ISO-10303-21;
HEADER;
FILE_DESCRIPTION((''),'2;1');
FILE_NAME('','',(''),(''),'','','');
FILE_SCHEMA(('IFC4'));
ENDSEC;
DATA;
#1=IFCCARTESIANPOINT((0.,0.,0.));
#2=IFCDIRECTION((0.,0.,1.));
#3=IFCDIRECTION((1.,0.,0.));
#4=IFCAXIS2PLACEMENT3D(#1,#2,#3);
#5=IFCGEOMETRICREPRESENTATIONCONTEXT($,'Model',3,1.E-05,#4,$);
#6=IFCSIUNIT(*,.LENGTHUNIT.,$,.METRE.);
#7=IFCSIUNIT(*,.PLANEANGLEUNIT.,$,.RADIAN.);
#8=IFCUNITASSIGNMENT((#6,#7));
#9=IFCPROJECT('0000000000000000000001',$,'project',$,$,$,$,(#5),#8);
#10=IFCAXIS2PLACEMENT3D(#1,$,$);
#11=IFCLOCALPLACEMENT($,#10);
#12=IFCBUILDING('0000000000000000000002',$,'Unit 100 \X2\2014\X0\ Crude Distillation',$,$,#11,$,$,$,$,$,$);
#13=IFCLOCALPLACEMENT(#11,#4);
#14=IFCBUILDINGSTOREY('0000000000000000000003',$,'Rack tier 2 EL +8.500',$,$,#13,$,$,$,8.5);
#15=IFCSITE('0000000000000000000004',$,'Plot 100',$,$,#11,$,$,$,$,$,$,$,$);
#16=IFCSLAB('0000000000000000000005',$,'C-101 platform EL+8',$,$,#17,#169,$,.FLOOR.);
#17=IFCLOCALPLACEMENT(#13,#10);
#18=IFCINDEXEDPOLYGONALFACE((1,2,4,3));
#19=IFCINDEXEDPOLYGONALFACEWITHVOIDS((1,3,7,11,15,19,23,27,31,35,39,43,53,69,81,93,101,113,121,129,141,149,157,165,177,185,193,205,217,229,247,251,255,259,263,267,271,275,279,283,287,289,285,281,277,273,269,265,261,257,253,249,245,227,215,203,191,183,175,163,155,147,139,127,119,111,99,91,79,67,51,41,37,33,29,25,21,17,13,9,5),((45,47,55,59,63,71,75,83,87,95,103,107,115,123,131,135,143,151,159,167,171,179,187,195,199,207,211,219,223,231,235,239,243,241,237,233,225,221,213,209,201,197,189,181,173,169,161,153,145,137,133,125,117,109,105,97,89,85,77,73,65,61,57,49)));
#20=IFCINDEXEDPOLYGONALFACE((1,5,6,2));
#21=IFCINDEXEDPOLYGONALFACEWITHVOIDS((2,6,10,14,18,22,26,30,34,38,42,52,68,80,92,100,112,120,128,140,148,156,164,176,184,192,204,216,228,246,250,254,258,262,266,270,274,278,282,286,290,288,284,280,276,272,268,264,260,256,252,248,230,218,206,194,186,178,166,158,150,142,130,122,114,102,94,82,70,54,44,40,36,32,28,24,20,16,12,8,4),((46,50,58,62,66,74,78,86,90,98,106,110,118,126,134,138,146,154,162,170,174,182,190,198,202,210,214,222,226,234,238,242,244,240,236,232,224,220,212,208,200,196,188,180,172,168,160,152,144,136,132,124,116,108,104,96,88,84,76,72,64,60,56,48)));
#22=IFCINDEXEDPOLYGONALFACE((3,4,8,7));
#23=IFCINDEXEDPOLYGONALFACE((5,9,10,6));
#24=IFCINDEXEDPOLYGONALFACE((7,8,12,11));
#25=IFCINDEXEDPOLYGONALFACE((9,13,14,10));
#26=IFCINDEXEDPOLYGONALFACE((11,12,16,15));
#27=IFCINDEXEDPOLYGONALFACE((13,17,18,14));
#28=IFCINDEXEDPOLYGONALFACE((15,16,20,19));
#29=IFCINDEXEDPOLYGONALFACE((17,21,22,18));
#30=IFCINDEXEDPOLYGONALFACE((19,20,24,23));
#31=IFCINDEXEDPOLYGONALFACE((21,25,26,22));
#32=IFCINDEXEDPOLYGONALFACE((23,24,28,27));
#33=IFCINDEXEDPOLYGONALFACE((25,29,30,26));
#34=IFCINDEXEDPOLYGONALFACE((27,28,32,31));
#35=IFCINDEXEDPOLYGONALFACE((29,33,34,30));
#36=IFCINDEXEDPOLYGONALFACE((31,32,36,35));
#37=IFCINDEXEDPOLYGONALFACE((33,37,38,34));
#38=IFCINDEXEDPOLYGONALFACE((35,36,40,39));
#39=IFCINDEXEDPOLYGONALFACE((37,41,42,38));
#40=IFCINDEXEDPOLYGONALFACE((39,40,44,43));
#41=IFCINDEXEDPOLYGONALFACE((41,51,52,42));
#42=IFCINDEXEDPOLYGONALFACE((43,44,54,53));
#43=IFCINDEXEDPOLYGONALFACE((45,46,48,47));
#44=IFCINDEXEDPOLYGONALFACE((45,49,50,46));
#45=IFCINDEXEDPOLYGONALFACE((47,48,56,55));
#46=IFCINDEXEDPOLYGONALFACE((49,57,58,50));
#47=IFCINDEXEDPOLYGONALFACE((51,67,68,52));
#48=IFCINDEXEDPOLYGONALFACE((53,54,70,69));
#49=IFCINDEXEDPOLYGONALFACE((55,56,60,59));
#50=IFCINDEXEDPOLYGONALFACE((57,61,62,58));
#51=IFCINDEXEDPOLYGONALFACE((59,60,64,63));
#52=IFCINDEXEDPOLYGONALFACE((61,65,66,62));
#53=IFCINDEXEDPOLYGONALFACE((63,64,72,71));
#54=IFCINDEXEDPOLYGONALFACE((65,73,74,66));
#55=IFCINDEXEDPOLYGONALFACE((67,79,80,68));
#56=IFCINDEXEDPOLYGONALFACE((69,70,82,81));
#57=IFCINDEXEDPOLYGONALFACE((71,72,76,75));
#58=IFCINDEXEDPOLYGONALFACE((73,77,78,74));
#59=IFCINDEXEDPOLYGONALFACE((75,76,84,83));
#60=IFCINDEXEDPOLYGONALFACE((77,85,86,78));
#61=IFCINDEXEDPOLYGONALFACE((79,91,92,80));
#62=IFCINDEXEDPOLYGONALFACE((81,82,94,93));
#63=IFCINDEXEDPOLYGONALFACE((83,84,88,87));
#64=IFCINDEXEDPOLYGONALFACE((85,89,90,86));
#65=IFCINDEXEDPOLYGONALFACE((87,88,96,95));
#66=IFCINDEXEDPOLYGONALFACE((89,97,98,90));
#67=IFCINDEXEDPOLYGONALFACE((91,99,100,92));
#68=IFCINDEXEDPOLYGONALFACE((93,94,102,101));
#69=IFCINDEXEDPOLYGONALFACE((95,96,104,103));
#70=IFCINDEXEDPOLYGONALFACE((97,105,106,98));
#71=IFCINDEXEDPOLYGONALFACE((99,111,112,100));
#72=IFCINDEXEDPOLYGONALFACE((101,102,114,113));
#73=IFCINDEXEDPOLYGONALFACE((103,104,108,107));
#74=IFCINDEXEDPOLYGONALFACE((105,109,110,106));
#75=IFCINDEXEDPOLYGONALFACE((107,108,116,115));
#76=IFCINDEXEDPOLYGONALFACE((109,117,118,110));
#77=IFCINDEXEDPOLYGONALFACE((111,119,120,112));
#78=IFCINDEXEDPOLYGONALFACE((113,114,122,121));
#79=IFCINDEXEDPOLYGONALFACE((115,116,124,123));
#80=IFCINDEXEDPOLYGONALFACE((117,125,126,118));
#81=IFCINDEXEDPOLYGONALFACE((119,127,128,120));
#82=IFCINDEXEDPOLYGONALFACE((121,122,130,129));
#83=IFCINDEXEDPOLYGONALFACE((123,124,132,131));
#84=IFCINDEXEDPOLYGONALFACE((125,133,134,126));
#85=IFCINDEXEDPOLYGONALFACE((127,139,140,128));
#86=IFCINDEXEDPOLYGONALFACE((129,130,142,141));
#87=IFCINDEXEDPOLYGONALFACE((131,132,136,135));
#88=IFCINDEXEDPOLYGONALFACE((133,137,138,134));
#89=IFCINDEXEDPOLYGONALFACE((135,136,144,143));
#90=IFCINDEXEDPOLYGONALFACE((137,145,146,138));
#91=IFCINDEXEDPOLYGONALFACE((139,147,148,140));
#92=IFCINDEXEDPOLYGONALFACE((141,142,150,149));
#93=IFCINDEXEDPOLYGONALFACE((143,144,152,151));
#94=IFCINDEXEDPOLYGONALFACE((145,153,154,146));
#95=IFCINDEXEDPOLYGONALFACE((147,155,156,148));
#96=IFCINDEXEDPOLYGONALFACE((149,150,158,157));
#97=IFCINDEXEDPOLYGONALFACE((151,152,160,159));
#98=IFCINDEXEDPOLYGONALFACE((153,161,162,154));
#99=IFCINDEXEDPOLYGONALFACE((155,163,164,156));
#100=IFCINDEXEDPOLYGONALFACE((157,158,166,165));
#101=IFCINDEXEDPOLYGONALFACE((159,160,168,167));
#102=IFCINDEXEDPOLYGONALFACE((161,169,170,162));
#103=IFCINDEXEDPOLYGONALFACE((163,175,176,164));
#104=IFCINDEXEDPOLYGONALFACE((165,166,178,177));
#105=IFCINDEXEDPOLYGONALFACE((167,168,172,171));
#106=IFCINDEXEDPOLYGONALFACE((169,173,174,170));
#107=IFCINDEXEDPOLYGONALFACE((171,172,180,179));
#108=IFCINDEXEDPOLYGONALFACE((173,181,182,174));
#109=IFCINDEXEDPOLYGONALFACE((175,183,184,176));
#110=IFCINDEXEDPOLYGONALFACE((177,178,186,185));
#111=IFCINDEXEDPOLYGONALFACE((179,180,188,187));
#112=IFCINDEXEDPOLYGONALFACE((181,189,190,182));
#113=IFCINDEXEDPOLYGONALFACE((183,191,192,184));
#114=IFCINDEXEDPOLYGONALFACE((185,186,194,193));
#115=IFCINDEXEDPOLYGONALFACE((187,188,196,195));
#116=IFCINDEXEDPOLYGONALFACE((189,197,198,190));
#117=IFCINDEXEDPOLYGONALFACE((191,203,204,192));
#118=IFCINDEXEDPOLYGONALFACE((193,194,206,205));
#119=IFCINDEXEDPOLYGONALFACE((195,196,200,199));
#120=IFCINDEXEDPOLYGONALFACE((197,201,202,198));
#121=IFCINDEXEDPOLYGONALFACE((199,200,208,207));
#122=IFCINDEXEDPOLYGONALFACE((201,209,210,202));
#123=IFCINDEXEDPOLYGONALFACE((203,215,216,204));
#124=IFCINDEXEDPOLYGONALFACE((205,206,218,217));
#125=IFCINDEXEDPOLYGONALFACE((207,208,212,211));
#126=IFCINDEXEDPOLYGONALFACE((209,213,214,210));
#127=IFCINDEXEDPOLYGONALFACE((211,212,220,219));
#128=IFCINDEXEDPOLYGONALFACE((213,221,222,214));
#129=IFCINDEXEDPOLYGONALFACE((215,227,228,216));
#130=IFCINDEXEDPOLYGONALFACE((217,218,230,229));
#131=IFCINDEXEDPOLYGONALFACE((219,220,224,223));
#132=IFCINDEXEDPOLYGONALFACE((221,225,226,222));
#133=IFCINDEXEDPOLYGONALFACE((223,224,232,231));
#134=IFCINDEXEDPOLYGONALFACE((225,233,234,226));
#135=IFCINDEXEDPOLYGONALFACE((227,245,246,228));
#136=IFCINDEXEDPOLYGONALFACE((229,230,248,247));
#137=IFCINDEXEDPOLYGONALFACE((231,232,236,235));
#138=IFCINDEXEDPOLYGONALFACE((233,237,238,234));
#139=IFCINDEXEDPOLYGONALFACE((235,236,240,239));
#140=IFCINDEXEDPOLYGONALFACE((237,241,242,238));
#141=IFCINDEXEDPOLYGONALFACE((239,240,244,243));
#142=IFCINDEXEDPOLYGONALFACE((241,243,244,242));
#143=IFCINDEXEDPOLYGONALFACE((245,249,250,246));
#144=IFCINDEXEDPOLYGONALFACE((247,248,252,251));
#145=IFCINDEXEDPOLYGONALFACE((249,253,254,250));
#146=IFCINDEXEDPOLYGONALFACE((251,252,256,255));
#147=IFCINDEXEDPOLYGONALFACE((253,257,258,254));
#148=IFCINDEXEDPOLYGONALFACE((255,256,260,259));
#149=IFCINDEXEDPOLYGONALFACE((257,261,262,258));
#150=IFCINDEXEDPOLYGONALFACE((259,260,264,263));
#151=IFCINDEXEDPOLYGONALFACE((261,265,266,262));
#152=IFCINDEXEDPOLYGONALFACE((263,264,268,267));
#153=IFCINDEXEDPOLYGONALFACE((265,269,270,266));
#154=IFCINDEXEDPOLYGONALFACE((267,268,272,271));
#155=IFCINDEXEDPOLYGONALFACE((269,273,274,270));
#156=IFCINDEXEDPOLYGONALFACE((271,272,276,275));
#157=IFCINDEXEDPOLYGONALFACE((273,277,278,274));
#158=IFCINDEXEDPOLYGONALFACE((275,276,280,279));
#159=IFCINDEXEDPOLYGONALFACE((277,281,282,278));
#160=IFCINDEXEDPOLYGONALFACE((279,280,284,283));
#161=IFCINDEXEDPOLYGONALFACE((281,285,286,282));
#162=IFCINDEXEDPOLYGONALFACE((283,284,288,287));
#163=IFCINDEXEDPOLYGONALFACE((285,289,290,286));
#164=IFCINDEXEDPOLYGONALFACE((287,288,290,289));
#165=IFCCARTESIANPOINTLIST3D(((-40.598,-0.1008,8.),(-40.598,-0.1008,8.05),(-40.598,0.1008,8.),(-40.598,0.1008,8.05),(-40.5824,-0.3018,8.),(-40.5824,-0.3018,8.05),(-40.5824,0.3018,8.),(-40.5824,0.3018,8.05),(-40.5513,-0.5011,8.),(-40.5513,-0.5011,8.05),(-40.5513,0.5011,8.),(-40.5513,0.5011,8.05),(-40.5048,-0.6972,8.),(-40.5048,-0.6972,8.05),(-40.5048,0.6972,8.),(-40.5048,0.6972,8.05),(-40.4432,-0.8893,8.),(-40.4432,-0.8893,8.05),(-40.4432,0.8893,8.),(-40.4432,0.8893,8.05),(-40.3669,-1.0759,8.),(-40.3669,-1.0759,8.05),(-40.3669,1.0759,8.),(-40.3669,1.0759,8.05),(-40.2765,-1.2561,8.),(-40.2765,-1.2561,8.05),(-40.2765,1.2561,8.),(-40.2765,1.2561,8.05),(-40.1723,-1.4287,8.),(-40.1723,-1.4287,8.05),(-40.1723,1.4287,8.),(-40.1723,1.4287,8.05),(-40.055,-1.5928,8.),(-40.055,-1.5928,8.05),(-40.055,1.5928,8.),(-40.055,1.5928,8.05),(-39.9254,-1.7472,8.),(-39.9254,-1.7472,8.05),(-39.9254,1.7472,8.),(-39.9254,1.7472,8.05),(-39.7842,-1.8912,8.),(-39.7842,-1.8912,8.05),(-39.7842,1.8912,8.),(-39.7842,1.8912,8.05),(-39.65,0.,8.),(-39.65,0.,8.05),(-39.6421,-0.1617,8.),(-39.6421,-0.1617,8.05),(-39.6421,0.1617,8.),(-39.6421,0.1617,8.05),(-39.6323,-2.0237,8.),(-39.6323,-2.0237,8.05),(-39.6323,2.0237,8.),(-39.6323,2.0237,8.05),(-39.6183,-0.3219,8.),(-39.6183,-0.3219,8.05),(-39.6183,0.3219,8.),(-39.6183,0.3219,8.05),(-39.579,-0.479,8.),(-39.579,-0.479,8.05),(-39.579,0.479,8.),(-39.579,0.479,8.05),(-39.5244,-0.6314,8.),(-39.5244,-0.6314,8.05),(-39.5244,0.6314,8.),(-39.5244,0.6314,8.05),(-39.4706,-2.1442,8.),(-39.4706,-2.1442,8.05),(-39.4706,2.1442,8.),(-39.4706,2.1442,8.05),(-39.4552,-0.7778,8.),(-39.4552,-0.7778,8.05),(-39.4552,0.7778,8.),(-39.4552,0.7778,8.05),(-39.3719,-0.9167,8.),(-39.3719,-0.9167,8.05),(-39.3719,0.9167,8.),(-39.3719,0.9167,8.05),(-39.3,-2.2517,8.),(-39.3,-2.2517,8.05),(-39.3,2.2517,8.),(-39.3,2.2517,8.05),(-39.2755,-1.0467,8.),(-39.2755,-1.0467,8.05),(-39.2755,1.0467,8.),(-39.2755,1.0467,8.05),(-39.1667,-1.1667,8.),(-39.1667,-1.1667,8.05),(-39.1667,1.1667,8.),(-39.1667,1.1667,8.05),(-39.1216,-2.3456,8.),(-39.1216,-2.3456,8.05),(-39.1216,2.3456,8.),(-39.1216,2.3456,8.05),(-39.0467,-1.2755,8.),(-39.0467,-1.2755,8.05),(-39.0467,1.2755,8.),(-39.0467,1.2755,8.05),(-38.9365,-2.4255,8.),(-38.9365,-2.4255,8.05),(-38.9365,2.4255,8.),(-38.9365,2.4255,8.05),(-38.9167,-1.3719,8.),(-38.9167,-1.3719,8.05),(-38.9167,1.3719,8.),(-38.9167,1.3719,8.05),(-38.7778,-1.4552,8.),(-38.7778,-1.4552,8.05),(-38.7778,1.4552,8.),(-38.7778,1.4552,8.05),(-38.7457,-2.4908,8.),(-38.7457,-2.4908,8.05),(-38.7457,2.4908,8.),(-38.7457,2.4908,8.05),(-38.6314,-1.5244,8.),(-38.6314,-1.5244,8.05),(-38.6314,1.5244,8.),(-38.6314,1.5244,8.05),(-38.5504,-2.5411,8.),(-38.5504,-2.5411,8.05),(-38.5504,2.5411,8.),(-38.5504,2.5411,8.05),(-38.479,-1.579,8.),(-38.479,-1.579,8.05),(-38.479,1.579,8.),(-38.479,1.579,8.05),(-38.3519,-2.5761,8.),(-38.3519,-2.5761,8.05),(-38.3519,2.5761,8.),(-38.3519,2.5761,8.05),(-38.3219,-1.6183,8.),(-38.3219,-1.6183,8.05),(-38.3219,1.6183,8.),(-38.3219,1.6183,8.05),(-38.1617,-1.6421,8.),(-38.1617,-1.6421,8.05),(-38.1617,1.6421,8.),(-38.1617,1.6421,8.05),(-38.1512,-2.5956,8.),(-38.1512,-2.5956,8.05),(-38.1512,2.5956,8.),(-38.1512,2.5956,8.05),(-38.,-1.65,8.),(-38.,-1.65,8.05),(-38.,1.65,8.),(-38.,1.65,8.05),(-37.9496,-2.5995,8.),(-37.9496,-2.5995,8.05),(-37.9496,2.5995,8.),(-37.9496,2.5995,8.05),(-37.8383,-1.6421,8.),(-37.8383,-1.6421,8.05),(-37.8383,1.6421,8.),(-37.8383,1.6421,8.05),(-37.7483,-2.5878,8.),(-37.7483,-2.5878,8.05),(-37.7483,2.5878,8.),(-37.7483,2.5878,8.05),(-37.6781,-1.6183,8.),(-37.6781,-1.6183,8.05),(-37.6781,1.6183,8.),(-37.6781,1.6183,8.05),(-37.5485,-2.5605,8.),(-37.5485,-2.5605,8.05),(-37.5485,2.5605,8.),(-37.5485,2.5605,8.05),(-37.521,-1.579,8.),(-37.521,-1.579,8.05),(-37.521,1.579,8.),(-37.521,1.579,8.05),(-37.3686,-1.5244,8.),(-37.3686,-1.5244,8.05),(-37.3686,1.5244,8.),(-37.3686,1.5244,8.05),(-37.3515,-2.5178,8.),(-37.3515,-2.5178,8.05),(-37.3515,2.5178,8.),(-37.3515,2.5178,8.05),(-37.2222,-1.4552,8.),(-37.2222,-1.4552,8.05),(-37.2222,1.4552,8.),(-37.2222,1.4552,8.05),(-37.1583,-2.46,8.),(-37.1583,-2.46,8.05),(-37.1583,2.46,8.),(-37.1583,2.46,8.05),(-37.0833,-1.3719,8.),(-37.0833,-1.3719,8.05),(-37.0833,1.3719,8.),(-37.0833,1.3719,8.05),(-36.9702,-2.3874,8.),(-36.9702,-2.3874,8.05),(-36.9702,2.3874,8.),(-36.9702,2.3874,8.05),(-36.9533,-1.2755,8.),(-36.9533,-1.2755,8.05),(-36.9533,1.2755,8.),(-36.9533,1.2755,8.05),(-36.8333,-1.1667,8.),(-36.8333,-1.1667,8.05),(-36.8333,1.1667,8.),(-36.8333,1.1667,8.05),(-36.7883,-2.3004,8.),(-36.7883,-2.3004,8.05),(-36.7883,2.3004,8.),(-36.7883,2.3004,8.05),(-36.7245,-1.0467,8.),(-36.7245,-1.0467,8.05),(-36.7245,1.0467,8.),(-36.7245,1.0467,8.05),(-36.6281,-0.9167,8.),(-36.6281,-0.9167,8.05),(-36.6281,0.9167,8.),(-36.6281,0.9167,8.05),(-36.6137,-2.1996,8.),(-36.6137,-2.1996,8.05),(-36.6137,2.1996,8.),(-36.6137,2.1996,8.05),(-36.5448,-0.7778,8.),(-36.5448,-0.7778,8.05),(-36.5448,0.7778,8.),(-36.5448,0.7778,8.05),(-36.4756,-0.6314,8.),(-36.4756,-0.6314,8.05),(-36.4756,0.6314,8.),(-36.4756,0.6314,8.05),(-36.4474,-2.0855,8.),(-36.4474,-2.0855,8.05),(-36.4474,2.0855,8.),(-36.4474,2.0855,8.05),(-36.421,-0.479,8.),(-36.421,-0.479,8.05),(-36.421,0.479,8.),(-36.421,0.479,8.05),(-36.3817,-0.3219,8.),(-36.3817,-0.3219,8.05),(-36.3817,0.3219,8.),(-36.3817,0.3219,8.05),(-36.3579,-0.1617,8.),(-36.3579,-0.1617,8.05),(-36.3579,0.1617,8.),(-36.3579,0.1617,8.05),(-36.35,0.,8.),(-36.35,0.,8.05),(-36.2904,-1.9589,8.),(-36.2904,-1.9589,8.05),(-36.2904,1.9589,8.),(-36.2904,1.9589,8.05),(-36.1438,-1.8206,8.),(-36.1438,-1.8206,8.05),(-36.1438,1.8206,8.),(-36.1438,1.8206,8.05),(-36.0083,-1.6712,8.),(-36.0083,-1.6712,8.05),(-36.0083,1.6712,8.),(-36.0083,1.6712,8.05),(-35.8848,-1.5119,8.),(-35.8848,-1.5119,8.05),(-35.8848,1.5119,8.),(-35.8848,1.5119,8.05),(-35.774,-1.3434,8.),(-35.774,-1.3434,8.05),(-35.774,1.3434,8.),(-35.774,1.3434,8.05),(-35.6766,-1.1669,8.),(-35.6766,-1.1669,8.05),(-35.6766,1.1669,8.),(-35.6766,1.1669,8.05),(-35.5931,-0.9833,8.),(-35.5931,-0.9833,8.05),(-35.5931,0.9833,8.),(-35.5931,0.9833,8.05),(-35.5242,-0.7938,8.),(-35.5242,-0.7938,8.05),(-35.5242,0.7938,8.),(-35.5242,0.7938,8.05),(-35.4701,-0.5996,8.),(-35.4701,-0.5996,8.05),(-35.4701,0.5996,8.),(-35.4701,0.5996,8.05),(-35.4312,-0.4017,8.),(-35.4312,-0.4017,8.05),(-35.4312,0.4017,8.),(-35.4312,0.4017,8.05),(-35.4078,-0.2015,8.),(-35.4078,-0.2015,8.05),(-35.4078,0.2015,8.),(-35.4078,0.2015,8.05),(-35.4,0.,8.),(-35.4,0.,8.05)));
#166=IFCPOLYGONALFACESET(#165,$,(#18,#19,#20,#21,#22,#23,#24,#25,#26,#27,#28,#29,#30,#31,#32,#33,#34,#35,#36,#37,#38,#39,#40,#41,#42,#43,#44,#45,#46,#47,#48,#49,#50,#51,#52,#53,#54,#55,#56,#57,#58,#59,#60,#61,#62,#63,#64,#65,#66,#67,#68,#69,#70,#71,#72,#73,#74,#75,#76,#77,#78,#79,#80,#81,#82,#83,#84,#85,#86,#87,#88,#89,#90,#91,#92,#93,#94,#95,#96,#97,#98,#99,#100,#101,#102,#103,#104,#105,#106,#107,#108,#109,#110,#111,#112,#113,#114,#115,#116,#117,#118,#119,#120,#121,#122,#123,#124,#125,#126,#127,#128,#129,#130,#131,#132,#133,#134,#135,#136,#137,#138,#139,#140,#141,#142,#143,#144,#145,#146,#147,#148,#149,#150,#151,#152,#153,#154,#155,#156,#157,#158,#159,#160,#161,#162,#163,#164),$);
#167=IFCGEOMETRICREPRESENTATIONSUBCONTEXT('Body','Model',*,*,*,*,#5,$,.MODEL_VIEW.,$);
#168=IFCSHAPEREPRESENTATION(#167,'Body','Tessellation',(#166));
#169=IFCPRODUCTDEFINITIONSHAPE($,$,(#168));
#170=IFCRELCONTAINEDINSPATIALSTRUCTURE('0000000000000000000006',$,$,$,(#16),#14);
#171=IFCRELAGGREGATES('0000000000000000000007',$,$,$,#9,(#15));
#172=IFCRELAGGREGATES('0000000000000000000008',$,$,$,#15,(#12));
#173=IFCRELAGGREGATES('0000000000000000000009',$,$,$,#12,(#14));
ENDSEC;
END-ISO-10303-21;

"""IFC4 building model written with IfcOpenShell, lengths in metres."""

from ifc_helpers import new_model, si_unit, frame, origin, origin_with_axes, origin_2d, place, context, subcontext, project, spatial, hollow_circle, extrude, element, save


model = new_model("IFC4")

# Units and contexts
model_context = context("Model", 3, precision=1e-05, world=origin_with_axes())
body_context = subcontext(model_context, "Body", "Model", "MODEL_VIEW")
ifc_project = project(units=[si_unit("LENGTHUNIT", "METRE"), si_unit("PLANEANGLEUNIT", "RADIAN")], contexts=[model_context])

# Site, building, storey
placement = place(None, origin())
site = spatial("IfcSite", under=ifc_project, at=placement, Name="Plot 100")
building = spatial("IfcBuilding", under=site, at=placement, Name="Unit 100 — Crude Distillation")
storey_placement = place(placement, origin_with_axes())
storey = spatial("IfcBuildingStorey", under=building, at=storey_placement, Name="Rack tier 2 EL +8.500", Elevation=8.5)

# Slab
slab_placement = place(storey_placement, origin_with_axes())
element("IfcSlab", 1, at=slab_placement, inside=storey, Name="C-101 platform EL+8", PredefinedType="FLOOR", context=body_context, shape_type="SweptSolid", body=[
    extrude(hollow_circle(Radius=2.6, WallThickness=0.95, at=origin_2d()), frame((-38.0, 0.0, 8.0), z_axis=(0.0, 0.0, 1.0), x_axis=(1.0, 0.0, 0.0)), (0.0, 0.0, 1.0), 0.05),
])

save(model, "model.ifc")
